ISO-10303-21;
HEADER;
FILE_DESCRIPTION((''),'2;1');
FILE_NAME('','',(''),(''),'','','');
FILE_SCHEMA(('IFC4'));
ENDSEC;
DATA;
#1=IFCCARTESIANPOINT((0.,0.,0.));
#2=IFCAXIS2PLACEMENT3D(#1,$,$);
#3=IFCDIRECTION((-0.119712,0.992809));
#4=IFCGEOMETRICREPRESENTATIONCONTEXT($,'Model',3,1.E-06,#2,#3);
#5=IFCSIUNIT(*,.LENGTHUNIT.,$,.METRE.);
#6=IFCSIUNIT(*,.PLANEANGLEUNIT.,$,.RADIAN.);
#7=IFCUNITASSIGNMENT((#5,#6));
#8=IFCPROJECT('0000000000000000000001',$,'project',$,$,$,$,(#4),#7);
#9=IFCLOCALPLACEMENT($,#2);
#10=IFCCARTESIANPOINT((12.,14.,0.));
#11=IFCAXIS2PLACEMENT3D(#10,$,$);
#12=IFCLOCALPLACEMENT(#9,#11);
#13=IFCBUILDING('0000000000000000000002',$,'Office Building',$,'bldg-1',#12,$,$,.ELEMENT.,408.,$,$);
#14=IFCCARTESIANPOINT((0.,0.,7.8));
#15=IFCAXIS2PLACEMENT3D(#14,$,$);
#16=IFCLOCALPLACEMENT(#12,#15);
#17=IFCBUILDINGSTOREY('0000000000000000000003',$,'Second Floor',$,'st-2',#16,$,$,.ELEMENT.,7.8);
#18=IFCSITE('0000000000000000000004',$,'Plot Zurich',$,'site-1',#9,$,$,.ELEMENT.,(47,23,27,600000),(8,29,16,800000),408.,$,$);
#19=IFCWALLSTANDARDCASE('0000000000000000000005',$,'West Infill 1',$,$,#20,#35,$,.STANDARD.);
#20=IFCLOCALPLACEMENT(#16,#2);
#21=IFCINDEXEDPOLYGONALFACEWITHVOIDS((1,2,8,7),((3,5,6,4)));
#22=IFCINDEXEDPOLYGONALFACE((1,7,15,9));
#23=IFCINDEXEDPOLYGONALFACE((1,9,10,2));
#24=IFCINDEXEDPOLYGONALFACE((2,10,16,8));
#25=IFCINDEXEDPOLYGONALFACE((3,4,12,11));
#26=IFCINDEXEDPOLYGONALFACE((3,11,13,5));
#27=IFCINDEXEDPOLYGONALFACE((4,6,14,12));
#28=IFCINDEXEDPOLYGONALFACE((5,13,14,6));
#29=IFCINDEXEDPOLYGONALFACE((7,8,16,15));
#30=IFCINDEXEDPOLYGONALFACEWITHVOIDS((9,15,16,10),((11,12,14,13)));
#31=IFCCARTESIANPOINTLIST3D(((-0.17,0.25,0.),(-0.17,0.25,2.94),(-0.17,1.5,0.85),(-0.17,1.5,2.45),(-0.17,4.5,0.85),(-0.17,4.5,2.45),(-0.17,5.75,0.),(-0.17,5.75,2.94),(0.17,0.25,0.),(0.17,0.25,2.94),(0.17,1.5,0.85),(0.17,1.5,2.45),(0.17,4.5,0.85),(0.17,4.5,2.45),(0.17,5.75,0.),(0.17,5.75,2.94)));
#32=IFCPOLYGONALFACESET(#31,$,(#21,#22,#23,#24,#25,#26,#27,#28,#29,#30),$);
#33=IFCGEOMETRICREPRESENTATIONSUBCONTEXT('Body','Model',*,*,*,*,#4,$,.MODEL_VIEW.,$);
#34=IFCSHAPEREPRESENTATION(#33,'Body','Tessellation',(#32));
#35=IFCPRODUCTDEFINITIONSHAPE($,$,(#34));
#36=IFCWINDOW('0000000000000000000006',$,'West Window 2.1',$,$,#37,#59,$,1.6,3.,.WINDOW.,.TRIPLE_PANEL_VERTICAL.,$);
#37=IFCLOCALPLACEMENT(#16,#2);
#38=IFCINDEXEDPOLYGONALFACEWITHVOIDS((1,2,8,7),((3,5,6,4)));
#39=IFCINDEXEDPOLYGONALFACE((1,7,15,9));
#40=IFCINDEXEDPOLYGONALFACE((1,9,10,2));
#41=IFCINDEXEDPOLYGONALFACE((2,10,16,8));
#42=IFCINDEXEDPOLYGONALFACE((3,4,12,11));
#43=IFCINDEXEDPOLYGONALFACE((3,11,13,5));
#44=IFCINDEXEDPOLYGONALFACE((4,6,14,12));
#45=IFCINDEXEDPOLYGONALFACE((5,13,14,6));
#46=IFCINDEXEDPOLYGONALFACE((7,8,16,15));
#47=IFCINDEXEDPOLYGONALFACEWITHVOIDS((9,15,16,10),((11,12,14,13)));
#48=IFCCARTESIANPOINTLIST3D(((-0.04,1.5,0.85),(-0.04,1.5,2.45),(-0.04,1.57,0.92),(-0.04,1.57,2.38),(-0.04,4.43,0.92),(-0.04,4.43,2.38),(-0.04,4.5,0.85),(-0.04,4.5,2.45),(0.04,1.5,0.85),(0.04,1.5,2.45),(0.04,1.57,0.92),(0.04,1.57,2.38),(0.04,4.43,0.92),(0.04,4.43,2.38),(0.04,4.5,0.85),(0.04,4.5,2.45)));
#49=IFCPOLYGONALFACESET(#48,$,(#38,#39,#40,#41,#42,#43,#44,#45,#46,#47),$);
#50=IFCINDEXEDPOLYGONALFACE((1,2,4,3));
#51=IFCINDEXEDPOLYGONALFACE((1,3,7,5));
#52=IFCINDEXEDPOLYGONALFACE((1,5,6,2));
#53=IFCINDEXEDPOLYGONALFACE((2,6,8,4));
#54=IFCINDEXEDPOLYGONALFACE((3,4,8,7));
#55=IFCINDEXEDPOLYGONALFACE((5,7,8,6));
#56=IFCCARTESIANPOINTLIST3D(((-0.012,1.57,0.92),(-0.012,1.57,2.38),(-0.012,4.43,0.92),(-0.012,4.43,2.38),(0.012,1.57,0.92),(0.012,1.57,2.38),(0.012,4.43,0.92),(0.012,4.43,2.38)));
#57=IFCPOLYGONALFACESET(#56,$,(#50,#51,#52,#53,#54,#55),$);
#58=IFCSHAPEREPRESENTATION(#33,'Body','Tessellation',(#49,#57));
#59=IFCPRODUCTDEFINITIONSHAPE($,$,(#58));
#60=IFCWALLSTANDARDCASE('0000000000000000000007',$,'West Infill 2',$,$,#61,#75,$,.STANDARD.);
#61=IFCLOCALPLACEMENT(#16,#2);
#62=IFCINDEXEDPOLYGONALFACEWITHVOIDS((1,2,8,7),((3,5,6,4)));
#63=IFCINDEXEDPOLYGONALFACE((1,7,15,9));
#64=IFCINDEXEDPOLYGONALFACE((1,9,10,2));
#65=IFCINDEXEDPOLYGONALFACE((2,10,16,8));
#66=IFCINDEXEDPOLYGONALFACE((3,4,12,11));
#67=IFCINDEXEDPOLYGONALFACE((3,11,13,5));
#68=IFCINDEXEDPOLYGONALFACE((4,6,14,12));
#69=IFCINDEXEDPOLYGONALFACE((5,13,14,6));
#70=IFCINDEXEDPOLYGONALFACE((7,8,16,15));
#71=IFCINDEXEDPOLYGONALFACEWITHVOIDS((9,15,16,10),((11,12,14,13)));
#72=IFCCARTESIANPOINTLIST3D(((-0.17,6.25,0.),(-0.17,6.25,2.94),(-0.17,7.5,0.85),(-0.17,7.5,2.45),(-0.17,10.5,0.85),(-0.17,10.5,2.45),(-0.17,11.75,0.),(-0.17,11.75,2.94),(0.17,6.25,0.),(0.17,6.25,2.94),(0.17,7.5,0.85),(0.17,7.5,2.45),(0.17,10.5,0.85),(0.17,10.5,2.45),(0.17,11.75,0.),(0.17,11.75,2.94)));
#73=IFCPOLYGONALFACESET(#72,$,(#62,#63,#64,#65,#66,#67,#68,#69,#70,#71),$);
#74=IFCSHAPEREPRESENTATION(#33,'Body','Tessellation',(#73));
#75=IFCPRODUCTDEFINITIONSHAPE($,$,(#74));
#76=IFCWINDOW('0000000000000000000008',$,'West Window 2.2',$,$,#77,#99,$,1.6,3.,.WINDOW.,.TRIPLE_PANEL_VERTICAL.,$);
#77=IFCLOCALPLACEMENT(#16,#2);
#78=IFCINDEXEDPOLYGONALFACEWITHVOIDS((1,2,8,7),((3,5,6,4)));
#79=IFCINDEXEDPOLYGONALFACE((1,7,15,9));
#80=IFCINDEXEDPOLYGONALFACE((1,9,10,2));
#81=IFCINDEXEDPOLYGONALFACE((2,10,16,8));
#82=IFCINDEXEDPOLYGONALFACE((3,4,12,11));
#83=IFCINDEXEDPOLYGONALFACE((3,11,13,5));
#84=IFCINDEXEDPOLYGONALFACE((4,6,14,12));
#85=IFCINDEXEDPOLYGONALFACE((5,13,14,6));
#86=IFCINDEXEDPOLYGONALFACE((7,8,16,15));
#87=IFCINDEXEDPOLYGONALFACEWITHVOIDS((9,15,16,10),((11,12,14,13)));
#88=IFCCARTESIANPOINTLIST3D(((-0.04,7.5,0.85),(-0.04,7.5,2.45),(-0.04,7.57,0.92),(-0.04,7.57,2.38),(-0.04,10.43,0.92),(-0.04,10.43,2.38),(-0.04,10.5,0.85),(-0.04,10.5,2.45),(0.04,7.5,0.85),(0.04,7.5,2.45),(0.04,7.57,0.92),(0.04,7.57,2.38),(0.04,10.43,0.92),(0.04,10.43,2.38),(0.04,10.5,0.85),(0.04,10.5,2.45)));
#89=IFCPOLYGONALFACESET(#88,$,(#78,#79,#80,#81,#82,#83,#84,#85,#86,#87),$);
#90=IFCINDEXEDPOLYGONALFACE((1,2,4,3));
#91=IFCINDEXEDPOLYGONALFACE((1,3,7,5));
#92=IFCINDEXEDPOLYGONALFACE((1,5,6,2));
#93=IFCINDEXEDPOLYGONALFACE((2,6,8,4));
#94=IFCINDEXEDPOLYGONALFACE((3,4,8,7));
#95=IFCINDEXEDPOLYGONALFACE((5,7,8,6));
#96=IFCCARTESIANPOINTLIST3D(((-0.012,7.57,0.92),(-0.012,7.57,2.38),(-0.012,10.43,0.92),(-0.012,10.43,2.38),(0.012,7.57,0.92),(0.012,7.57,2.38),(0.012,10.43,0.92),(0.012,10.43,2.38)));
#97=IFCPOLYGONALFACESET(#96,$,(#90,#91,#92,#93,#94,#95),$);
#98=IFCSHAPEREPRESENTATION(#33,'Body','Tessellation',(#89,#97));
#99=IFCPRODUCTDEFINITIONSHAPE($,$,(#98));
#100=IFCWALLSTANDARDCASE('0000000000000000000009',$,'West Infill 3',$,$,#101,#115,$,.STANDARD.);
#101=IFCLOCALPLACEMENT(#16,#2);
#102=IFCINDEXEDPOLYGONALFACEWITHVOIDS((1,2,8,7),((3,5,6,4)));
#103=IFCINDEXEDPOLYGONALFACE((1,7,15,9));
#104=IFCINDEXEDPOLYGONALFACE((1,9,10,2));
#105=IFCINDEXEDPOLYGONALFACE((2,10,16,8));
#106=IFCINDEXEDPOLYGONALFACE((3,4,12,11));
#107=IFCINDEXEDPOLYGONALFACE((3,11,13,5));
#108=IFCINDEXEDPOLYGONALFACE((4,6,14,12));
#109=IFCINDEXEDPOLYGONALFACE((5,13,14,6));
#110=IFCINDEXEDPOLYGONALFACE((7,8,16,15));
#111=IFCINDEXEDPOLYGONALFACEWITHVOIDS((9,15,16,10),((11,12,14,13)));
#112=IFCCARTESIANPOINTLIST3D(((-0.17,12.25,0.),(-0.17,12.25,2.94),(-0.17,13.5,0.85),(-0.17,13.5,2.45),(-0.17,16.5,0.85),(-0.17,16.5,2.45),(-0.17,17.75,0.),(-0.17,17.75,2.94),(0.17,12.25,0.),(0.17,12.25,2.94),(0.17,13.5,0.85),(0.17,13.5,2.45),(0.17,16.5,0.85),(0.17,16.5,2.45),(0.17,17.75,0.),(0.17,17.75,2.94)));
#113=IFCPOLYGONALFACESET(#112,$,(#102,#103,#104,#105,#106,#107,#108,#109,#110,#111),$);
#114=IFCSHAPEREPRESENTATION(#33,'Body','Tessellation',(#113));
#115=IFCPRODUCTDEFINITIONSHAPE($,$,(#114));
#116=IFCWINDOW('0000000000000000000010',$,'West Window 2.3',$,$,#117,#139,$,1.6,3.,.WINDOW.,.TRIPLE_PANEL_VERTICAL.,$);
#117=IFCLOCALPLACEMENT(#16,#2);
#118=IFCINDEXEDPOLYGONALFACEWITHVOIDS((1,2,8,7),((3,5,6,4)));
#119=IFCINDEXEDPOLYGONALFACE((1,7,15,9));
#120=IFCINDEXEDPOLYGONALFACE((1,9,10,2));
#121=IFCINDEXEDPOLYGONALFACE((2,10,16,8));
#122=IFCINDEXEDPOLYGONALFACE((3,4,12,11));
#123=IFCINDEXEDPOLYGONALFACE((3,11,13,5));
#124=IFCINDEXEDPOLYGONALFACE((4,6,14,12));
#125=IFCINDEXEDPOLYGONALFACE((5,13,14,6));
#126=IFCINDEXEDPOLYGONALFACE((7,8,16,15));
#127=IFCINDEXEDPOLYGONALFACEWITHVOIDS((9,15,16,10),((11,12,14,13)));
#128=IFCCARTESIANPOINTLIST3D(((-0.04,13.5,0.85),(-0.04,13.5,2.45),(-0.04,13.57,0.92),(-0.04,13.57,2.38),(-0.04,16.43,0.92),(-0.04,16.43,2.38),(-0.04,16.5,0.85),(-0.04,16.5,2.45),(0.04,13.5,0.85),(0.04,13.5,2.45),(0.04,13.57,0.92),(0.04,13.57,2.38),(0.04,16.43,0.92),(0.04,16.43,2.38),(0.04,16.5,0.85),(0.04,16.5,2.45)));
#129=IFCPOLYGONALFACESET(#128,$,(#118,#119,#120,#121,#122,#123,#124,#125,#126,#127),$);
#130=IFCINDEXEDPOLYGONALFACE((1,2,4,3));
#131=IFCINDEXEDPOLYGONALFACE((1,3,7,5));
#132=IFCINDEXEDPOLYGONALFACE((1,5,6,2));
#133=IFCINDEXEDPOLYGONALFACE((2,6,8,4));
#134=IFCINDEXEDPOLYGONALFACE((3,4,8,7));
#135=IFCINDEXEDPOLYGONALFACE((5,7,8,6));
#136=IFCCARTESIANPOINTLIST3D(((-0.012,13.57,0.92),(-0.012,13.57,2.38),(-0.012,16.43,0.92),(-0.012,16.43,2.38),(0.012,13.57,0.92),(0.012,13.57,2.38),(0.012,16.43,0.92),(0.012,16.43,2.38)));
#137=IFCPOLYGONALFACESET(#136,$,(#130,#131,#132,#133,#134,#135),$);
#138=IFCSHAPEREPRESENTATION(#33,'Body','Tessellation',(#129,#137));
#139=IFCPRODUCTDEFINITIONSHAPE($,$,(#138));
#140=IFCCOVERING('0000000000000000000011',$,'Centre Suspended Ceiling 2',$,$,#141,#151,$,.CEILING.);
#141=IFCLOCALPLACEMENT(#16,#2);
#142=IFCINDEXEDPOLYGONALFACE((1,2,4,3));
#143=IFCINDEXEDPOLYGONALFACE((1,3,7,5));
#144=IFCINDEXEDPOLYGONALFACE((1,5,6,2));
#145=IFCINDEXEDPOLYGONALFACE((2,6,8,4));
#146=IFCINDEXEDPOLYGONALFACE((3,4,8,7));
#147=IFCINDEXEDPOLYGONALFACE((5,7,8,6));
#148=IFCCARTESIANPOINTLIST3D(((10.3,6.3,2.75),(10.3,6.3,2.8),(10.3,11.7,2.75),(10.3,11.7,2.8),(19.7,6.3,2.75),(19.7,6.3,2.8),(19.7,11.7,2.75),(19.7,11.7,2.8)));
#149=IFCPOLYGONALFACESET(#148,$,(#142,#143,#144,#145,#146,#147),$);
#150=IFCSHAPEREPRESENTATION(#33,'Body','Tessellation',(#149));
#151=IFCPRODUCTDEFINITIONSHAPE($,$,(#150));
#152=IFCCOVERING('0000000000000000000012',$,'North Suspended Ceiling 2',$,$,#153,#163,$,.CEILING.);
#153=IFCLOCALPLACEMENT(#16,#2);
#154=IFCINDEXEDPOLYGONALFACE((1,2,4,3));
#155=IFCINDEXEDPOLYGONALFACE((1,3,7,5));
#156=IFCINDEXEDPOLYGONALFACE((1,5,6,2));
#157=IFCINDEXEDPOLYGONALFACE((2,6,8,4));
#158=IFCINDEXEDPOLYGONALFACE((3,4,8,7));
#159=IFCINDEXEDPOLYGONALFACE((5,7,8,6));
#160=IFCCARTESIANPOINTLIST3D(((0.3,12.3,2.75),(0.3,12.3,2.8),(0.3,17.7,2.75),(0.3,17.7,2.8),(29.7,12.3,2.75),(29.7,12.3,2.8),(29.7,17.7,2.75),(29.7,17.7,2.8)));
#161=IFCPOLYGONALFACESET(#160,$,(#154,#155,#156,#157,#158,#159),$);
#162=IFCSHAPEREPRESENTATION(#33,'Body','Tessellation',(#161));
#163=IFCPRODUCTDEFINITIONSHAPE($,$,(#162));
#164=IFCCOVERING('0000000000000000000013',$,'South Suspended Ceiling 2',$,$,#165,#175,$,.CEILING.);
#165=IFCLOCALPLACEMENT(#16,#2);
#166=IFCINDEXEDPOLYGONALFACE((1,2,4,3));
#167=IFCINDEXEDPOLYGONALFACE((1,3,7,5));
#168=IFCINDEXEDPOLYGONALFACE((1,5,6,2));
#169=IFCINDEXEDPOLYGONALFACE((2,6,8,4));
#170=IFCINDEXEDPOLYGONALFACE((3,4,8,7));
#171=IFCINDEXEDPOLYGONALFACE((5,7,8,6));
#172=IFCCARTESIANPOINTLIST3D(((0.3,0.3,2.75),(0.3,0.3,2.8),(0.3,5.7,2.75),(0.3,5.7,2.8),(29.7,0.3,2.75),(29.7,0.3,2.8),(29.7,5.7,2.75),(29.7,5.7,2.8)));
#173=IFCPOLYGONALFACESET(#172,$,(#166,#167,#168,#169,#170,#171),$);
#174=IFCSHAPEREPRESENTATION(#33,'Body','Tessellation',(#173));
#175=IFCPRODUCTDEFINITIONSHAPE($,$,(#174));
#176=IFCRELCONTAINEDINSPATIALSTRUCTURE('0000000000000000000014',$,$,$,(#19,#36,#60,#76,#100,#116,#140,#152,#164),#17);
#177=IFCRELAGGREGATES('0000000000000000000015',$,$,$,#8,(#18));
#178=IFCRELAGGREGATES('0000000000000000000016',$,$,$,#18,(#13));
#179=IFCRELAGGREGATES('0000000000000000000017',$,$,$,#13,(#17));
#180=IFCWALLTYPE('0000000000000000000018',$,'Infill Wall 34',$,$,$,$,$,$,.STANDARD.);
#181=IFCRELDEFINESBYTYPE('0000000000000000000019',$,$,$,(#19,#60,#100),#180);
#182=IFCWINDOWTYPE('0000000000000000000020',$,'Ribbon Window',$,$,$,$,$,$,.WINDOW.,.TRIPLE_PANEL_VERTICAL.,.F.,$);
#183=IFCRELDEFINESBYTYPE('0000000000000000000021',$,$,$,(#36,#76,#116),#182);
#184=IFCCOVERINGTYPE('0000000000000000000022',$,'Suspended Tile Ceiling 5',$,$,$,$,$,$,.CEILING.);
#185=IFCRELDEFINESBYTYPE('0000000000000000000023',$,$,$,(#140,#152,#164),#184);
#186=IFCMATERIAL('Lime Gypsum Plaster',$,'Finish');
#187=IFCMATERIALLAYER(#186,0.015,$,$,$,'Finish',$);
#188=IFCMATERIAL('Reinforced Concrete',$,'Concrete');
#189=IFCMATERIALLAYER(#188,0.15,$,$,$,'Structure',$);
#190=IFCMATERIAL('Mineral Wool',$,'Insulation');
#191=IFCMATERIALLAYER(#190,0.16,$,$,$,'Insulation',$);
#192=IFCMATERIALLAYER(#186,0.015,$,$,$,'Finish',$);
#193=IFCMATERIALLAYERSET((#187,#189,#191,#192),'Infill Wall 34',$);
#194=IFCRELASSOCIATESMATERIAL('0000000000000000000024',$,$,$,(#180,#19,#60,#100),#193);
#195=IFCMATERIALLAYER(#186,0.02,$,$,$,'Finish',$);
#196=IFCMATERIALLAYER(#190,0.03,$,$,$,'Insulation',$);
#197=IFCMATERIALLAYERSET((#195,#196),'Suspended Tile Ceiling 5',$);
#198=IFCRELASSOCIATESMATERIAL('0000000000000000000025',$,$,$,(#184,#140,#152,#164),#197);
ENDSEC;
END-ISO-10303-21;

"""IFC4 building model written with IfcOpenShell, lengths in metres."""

from ifc_helpers import new_model, si_unit, direction, frame, frame_2d, origin, origin_2d, place, context, subcontext, project, spatial, polyline, rectangle, outline, extrude, material, layer, layer_set, layer_usage, type_object, element, fill, save


model = new_model("IFC4")

# Units and contexts
model_context = context("Model", 3, precision=1e-06, world=origin(), true_north=direction((-0.119712, 0.992809)))
body_context = subcontext(model_context, "Body", "Model", "MODEL_VIEW")
ifc_project = project(units=[si_unit("LENGTHUNIT", "METRE"), si_unit("PLANEANGLEUNIT", "RADIAN")], contexts=[model_context])

# Site, building, storey
site_placement = place(None, origin())
site = spatial("IfcSite", under=ifc_project, at=site_placement, Name="Plot Zurich", ObjectType="site-1", CompositionType="ELEMENT", RefLatitude=(47, 23, 27, 600000), RefLongitude=(8, 29, 16, 800000), RefElevation=408.0)
building_placement = place(site_placement, frame((12.0, 14.0, 0.0)))
building = spatial("IfcBuilding", under=site, at=building_placement, Name="Office Building", ObjectType="bldg-1", CompositionType="ELEMENT", ElevationOfRefHeight=408.0)
storey_placement = place(building_placement, frame((0.0, 0.0, 7.8)))
storey = spatial("IfcBuildingStorey", under=building, at=storey_placement, Name="Second Floor", ObjectType="st-2", CompositionType="ELEMENT", Elevation=7.8)

# Shared definitions
ifc_material_1 = material(Name="Reinforced Concrete", Category="Concrete")

# Walls, openings, windows
ifc_material_2 = material(Name="Lime Gypsum Plaster", Category="Finish")
ifc_layer_1 = layer(ifc_material_2, 0.015, Category="Finish")
ifc_layer_2 = layer(ifc_material_1, 0.15, Category="Structure")
ifc_material_3 = material(Name="Mineral Wool", Category="Insulation")
ifc_layer_3 = layer(ifc_material_3, 0.16, Category="Insulation")
ifc_layer_4 = layer(ifc_material_2, 0.015, Category="Finish")
ifc_layer_set_1 = layer_set([ifc_layer_1, ifc_layer_2, ifc_layer_3, ifc_layer_4], Name="Infill Wall 34")
ifc_layer_usage_1 = layer_usage(ifc_layer_set_1, "AXIS2", "NEGATIVE", 0.17)
wall_type_1 = type_object("IfcWallType", Name="Infill Wall 34", PredefinedType="STANDARD", material=ifc_layer_set_1)
wall_1_placement = place(storey_placement, frame((0.0, 5.75, 0.0), z_axis=(0.0, 0.0, 1.0), x_axis=(0.0, -1.0, 0.0)))
wall_1 = element("IfcWallStandardCase", 1, at=wall_1_placement, inside=storey, type_object=wall_type_1, material=ifc_layer_usage_1, Name="West Infill 1", PredefinedType="STANDARD", context=body_context, shape_type="SweptSolid", body=[
    extrude(rectangle(XDim=5.5, YDim=0.34, at=frame_2d((2.75, 0.0))), origin(), (0.0, 0.0, 1.0), 2.94),
])
opening_1_placement = place(wall_1_placement, frame((2.75, 0.0, 0.85)))
opening_1 = element("IfcOpeningElement", 2, at=opening_1_placement, cuts=wall_1, PredefinedType="OPENING", context=body_context, shape_type="SweptSolid", body=[
    extrude(rectangle(XDim=3.0, YDim=0.34, at=origin_2d()), origin(), (0.0, 0.0, 1.0), 1.6),
])
window_type = type_object("IfcWindowType", Name="Ribbon Window", ParameterTakesPrecedence=False, PartitioningType="TRIPLE_PANEL_VERTICAL", PredefinedType="WINDOW")
window_1_placement = place(opening_1_placement, frame((0.0, 0.0, 0.0), z_axis=(0.0, -1.0, 0.0), x_axis=(1.0, 0.0, 0.0)))
window_1 = element("IfcWindow", 3, at=window_1_placement, inside=storey, type_object=window_type, Name="West Window 2.1", OverallHeight=1.6, OverallWidth=3.0, PartitioningType="TRIPLE_PANEL_VERTICAL", PredefinedType="WINDOW", context=body_context, shape_type="SweptSolid", body=[
    extrude(outline(polyline([(-1.5, 0.0), (1.5, 0.0), (1.5, 1.6), (-1.5, 1.6), (-1.5, 0.0)]), holes=[polyline([(-1.43, 0.07), (1.43, 0.07), (1.43, 1.53), (-1.43, 1.53), (-1.43, 0.07)])]), frame((0.0, 0.0, -0.04)), (0.0, 0.0, 1.0), 0.08),
    extrude(rectangle(XDim=2.86, YDim=1.46, at=frame_2d((0.0, 0.8))), frame((0.0, 0.0, -0.012)), (0.0, 0.0, 1.0), 0.024),
])
fill(opening_1, window_1)
ifc_layer_usage_2 = layer_usage(ifc_layer_set_1, "AXIS2", "NEGATIVE", 0.17)
wall_2_placement = place(storey_placement, frame((0.0, 11.75, 0.0), z_axis=(0.0, 0.0, 1.0), x_axis=(0.0, -1.0, 0.0)))
wall_2 = element("IfcWallStandardCase", 4, at=wall_2_placement, inside=storey, type_object=wall_type_1, material=ifc_layer_usage_2, Name="West Infill 2", PredefinedType="STANDARD", context=body_context, shape_type="SweptSolid", body=[
    extrude(rectangle(XDim=5.5, YDim=0.34, at=frame_2d((2.75, 0.0))), origin(), (0.0, 0.0, 1.0), 2.94),
])
opening_2_placement = place(wall_2_placement, frame((2.75, 0.0, 0.85)))
opening_2 = element("IfcOpeningElement", 5, at=opening_2_placement, cuts=wall_2, PredefinedType="OPENING", context=body_context, shape_type="SweptSolid", body=[
    extrude(rectangle(XDim=3.0, YDim=0.34, at=origin_2d()), origin(), (0.0, 0.0, 1.0), 1.6),
])
window_2_placement = place(opening_2_placement, frame((0.0, 0.0, 0.0), z_axis=(0.0, -1.0, 0.0), x_axis=(1.0, 0.0, 0.0)))
window_2 = element("IfcWindow", 6, at=window_2_placement, inside=storey, type_object=window_type, Name="West Window 2.2", OverallHeight=1.6, OverallWidth=3.0, PartitioningType="TRIPLE_PANEL_VERTICAL", PredefinedType="WINDOW", context=body_context, shape_type="SweptSolid", body=[
    extrude(outline(polyline([(-1.5, 0.0), (1.5, 0.0), (1.5, 1.6), (-1.5, 1.6), (-1.5, 0.0)]), holes=[polyline([(-1.43, 0.07), (1.43, 0.07), (1.43, 1.53), (-1.43, 1.53), (-1.43, 0.07)])]), frame((0.0, 0.0, -0.04)), (0.0, 0.0, 1.0), 0.08),
    extrude(rectangle(XDim=2.86, YDim=1.46, at=frame_2d((0.0, 0.8))), frame((0.0, 0.0, -0.012)), (0.0, 0.0, 1.0), 0.024),
])
fill(opening_2, window_2)
ifc_layer_usage_3 = layer_usage(ifc_layer_set_1, "AXIS2", "NEGATIVE", 0.17)
wall_3_placement = place(storey_placement, frame((0.0, 17.75, 0.0), z_axis=(0.0, 0.0, 1.0), x_axis=(0.0, -1.0, 0.0)))
wall_3 = element("IfcWallStandardCase", 7, at=wall_3_placement, inside=storey, type_object=wall_type_1, material=ifc_layer_usage_3, Name="West Infill 3", PredefinedType="STANDARD", context=body_context, shape_type="SweptSolid", body=[
    extrude(rectangle(XDim=5.5, YDim=0.34, at=frame_2d((2.75, 0.0))), origin(), (0.0, 0.0, 1.0), 2.94),
])
opening_3_placement = place(wall_3_placement, frame((2.75, 0.0, 0.85)))
opening_3 = element("IfcOpeningElement", 8, at=opening_3_placement, cuts=wall_3, PredefinedType="OPENING", context=body_context, shape_type="SweptSolid", body=[
    extrude(rectangle(XDim=3.0, YDim=0.34, at=origin_2d()), origin(), (0.0, 0.0, 1.0), 1.6),
])
window_3_placement = place(opening_3_placement, frame((0.0, 0.0, 0.0), z_axis=(0.0, -1.0, 0.0), x_axis=(1.0, 0.0, 0.0)))
window_3 = element("IfcWindow", 9, at=window_3_placement, inside=storey, type_object=window_type, Name="West Window 2.3", OverallHeight=1.6, OverallWidth=3.0, PartitioningType="TRIPLE_PANEL_VERTICAL", PredefinedType="WINDOW", context=body_context, shape_type="SweptSolid", body=[
    extrude(outline(polyline([(-1.5, 0.0), (1.5, 0.0), (1.5, 1.6), (-1.5, 1.6), (-1.5, 0.0)]), holes=[polyline([(-1.43, 0.07), (1.43, 0.07), (1.43, 1.53), (-1.43, 1.53), (-1.43, 0.07)])]), frame((0.0, 0.0, -0.04)), (0.0, 0.0, 1.0), 0.08),
    extrude(rectangle(XDim=2.86, YDim=1.46, at=frame_2d((0.0, 0.8))), frame((0.0, 0.0, -0.012)), (0.0, 0.0, 1.0), 0.024),
])
fill(opening_3, window_3)

# Coverings
ifc_layer_5 = layer(ifc_material_2, 0.02, Category="Finish")
ifc_layer_6 = layer(ifc_material_3, 0.03, Category="Insulation")
ifc_layer_set_2 = layer_set([ifc_layer_5, ifc_layer_6], Name="Suspended Tile Ceiling 5")
ifc_layer_usage_4 = layer_usage(ifc_layer_set_2, "AXIS3", "NEGATIVE", 0.05)
covering_type = type_object("IfcCoveringType", Name="Suspended Tile Ceiling 5", PredefinedType="CEILING", material=ifc_layer_set_2)
covering_1_placement = place(storey_placement, frame((0.0, 0.0, 2.75)))
element("IfcCovering", 10, at=covering_1_placement, inside=storey, type_object=covering_type, material=ifc_layer_usage_4, Name="Centre Suspended Ceiling 2", PredefinedType="CEILING", context=body_context, shape_type="SweptSolid", body=[
    extrude(outline(polyline([(10.3, 6.3), (19.7, 6.3), (19.7, 11.7), (10.3, 11.7), (10.3, 6.3)])), origin(), (0.0, 0.0, 1.0), 0.05),
])
ifc_layer_usage_5 = layer_usage(ifc_layer_set_2, "AXIS3", "NEGATIVE", 0.05)
covering_2_placement = place(storey_placement, frame((0.0, 0.0, 2.75)))
element("IfcCovering", 11, at=covering_2_placement, inside=storey, type_object=covering_type, material=ifc_layer_usage_5, Name="North Suspended Ceiling 2", PredefinedType="CEILING", context=body_context, shape_type="SweptSolid", body=[
    extrude(outline(polyline([(0.3, 12.3), (29.7, 12.3), (29.7, 17.7), (0.3, 17.7), (0.3, 12.3)])), origin(), (0.0, 0.0, 1.0), 0.05),
])
ifc_layer_usage_6 = layer_usage(ifc_layer_set_2, "AXIS3", "NEGATIVE", 0.05)
covering_3_placement = place(storey_placement, frame((0.0, 0.0, 2.75)))
element("IfcCovering", 12, at=covering_3_placement, inside=storey, type_object=covering_type, material=ifc_layer_usage_6, Name="South Suspended Ceiling 2", PredefinedType="CEILING", context=body_context, shape_type="SweptSolid", body=[
    extrude(outline(polyline([(0.3, 0.3), (29.7, 0.3), (29.7, 5.7), (0.3, 5.7), (0.3, 0.3)])), origin(), (0.0, 0.0, 1.0), 0.05),
])

save(model, "model.ifc")
